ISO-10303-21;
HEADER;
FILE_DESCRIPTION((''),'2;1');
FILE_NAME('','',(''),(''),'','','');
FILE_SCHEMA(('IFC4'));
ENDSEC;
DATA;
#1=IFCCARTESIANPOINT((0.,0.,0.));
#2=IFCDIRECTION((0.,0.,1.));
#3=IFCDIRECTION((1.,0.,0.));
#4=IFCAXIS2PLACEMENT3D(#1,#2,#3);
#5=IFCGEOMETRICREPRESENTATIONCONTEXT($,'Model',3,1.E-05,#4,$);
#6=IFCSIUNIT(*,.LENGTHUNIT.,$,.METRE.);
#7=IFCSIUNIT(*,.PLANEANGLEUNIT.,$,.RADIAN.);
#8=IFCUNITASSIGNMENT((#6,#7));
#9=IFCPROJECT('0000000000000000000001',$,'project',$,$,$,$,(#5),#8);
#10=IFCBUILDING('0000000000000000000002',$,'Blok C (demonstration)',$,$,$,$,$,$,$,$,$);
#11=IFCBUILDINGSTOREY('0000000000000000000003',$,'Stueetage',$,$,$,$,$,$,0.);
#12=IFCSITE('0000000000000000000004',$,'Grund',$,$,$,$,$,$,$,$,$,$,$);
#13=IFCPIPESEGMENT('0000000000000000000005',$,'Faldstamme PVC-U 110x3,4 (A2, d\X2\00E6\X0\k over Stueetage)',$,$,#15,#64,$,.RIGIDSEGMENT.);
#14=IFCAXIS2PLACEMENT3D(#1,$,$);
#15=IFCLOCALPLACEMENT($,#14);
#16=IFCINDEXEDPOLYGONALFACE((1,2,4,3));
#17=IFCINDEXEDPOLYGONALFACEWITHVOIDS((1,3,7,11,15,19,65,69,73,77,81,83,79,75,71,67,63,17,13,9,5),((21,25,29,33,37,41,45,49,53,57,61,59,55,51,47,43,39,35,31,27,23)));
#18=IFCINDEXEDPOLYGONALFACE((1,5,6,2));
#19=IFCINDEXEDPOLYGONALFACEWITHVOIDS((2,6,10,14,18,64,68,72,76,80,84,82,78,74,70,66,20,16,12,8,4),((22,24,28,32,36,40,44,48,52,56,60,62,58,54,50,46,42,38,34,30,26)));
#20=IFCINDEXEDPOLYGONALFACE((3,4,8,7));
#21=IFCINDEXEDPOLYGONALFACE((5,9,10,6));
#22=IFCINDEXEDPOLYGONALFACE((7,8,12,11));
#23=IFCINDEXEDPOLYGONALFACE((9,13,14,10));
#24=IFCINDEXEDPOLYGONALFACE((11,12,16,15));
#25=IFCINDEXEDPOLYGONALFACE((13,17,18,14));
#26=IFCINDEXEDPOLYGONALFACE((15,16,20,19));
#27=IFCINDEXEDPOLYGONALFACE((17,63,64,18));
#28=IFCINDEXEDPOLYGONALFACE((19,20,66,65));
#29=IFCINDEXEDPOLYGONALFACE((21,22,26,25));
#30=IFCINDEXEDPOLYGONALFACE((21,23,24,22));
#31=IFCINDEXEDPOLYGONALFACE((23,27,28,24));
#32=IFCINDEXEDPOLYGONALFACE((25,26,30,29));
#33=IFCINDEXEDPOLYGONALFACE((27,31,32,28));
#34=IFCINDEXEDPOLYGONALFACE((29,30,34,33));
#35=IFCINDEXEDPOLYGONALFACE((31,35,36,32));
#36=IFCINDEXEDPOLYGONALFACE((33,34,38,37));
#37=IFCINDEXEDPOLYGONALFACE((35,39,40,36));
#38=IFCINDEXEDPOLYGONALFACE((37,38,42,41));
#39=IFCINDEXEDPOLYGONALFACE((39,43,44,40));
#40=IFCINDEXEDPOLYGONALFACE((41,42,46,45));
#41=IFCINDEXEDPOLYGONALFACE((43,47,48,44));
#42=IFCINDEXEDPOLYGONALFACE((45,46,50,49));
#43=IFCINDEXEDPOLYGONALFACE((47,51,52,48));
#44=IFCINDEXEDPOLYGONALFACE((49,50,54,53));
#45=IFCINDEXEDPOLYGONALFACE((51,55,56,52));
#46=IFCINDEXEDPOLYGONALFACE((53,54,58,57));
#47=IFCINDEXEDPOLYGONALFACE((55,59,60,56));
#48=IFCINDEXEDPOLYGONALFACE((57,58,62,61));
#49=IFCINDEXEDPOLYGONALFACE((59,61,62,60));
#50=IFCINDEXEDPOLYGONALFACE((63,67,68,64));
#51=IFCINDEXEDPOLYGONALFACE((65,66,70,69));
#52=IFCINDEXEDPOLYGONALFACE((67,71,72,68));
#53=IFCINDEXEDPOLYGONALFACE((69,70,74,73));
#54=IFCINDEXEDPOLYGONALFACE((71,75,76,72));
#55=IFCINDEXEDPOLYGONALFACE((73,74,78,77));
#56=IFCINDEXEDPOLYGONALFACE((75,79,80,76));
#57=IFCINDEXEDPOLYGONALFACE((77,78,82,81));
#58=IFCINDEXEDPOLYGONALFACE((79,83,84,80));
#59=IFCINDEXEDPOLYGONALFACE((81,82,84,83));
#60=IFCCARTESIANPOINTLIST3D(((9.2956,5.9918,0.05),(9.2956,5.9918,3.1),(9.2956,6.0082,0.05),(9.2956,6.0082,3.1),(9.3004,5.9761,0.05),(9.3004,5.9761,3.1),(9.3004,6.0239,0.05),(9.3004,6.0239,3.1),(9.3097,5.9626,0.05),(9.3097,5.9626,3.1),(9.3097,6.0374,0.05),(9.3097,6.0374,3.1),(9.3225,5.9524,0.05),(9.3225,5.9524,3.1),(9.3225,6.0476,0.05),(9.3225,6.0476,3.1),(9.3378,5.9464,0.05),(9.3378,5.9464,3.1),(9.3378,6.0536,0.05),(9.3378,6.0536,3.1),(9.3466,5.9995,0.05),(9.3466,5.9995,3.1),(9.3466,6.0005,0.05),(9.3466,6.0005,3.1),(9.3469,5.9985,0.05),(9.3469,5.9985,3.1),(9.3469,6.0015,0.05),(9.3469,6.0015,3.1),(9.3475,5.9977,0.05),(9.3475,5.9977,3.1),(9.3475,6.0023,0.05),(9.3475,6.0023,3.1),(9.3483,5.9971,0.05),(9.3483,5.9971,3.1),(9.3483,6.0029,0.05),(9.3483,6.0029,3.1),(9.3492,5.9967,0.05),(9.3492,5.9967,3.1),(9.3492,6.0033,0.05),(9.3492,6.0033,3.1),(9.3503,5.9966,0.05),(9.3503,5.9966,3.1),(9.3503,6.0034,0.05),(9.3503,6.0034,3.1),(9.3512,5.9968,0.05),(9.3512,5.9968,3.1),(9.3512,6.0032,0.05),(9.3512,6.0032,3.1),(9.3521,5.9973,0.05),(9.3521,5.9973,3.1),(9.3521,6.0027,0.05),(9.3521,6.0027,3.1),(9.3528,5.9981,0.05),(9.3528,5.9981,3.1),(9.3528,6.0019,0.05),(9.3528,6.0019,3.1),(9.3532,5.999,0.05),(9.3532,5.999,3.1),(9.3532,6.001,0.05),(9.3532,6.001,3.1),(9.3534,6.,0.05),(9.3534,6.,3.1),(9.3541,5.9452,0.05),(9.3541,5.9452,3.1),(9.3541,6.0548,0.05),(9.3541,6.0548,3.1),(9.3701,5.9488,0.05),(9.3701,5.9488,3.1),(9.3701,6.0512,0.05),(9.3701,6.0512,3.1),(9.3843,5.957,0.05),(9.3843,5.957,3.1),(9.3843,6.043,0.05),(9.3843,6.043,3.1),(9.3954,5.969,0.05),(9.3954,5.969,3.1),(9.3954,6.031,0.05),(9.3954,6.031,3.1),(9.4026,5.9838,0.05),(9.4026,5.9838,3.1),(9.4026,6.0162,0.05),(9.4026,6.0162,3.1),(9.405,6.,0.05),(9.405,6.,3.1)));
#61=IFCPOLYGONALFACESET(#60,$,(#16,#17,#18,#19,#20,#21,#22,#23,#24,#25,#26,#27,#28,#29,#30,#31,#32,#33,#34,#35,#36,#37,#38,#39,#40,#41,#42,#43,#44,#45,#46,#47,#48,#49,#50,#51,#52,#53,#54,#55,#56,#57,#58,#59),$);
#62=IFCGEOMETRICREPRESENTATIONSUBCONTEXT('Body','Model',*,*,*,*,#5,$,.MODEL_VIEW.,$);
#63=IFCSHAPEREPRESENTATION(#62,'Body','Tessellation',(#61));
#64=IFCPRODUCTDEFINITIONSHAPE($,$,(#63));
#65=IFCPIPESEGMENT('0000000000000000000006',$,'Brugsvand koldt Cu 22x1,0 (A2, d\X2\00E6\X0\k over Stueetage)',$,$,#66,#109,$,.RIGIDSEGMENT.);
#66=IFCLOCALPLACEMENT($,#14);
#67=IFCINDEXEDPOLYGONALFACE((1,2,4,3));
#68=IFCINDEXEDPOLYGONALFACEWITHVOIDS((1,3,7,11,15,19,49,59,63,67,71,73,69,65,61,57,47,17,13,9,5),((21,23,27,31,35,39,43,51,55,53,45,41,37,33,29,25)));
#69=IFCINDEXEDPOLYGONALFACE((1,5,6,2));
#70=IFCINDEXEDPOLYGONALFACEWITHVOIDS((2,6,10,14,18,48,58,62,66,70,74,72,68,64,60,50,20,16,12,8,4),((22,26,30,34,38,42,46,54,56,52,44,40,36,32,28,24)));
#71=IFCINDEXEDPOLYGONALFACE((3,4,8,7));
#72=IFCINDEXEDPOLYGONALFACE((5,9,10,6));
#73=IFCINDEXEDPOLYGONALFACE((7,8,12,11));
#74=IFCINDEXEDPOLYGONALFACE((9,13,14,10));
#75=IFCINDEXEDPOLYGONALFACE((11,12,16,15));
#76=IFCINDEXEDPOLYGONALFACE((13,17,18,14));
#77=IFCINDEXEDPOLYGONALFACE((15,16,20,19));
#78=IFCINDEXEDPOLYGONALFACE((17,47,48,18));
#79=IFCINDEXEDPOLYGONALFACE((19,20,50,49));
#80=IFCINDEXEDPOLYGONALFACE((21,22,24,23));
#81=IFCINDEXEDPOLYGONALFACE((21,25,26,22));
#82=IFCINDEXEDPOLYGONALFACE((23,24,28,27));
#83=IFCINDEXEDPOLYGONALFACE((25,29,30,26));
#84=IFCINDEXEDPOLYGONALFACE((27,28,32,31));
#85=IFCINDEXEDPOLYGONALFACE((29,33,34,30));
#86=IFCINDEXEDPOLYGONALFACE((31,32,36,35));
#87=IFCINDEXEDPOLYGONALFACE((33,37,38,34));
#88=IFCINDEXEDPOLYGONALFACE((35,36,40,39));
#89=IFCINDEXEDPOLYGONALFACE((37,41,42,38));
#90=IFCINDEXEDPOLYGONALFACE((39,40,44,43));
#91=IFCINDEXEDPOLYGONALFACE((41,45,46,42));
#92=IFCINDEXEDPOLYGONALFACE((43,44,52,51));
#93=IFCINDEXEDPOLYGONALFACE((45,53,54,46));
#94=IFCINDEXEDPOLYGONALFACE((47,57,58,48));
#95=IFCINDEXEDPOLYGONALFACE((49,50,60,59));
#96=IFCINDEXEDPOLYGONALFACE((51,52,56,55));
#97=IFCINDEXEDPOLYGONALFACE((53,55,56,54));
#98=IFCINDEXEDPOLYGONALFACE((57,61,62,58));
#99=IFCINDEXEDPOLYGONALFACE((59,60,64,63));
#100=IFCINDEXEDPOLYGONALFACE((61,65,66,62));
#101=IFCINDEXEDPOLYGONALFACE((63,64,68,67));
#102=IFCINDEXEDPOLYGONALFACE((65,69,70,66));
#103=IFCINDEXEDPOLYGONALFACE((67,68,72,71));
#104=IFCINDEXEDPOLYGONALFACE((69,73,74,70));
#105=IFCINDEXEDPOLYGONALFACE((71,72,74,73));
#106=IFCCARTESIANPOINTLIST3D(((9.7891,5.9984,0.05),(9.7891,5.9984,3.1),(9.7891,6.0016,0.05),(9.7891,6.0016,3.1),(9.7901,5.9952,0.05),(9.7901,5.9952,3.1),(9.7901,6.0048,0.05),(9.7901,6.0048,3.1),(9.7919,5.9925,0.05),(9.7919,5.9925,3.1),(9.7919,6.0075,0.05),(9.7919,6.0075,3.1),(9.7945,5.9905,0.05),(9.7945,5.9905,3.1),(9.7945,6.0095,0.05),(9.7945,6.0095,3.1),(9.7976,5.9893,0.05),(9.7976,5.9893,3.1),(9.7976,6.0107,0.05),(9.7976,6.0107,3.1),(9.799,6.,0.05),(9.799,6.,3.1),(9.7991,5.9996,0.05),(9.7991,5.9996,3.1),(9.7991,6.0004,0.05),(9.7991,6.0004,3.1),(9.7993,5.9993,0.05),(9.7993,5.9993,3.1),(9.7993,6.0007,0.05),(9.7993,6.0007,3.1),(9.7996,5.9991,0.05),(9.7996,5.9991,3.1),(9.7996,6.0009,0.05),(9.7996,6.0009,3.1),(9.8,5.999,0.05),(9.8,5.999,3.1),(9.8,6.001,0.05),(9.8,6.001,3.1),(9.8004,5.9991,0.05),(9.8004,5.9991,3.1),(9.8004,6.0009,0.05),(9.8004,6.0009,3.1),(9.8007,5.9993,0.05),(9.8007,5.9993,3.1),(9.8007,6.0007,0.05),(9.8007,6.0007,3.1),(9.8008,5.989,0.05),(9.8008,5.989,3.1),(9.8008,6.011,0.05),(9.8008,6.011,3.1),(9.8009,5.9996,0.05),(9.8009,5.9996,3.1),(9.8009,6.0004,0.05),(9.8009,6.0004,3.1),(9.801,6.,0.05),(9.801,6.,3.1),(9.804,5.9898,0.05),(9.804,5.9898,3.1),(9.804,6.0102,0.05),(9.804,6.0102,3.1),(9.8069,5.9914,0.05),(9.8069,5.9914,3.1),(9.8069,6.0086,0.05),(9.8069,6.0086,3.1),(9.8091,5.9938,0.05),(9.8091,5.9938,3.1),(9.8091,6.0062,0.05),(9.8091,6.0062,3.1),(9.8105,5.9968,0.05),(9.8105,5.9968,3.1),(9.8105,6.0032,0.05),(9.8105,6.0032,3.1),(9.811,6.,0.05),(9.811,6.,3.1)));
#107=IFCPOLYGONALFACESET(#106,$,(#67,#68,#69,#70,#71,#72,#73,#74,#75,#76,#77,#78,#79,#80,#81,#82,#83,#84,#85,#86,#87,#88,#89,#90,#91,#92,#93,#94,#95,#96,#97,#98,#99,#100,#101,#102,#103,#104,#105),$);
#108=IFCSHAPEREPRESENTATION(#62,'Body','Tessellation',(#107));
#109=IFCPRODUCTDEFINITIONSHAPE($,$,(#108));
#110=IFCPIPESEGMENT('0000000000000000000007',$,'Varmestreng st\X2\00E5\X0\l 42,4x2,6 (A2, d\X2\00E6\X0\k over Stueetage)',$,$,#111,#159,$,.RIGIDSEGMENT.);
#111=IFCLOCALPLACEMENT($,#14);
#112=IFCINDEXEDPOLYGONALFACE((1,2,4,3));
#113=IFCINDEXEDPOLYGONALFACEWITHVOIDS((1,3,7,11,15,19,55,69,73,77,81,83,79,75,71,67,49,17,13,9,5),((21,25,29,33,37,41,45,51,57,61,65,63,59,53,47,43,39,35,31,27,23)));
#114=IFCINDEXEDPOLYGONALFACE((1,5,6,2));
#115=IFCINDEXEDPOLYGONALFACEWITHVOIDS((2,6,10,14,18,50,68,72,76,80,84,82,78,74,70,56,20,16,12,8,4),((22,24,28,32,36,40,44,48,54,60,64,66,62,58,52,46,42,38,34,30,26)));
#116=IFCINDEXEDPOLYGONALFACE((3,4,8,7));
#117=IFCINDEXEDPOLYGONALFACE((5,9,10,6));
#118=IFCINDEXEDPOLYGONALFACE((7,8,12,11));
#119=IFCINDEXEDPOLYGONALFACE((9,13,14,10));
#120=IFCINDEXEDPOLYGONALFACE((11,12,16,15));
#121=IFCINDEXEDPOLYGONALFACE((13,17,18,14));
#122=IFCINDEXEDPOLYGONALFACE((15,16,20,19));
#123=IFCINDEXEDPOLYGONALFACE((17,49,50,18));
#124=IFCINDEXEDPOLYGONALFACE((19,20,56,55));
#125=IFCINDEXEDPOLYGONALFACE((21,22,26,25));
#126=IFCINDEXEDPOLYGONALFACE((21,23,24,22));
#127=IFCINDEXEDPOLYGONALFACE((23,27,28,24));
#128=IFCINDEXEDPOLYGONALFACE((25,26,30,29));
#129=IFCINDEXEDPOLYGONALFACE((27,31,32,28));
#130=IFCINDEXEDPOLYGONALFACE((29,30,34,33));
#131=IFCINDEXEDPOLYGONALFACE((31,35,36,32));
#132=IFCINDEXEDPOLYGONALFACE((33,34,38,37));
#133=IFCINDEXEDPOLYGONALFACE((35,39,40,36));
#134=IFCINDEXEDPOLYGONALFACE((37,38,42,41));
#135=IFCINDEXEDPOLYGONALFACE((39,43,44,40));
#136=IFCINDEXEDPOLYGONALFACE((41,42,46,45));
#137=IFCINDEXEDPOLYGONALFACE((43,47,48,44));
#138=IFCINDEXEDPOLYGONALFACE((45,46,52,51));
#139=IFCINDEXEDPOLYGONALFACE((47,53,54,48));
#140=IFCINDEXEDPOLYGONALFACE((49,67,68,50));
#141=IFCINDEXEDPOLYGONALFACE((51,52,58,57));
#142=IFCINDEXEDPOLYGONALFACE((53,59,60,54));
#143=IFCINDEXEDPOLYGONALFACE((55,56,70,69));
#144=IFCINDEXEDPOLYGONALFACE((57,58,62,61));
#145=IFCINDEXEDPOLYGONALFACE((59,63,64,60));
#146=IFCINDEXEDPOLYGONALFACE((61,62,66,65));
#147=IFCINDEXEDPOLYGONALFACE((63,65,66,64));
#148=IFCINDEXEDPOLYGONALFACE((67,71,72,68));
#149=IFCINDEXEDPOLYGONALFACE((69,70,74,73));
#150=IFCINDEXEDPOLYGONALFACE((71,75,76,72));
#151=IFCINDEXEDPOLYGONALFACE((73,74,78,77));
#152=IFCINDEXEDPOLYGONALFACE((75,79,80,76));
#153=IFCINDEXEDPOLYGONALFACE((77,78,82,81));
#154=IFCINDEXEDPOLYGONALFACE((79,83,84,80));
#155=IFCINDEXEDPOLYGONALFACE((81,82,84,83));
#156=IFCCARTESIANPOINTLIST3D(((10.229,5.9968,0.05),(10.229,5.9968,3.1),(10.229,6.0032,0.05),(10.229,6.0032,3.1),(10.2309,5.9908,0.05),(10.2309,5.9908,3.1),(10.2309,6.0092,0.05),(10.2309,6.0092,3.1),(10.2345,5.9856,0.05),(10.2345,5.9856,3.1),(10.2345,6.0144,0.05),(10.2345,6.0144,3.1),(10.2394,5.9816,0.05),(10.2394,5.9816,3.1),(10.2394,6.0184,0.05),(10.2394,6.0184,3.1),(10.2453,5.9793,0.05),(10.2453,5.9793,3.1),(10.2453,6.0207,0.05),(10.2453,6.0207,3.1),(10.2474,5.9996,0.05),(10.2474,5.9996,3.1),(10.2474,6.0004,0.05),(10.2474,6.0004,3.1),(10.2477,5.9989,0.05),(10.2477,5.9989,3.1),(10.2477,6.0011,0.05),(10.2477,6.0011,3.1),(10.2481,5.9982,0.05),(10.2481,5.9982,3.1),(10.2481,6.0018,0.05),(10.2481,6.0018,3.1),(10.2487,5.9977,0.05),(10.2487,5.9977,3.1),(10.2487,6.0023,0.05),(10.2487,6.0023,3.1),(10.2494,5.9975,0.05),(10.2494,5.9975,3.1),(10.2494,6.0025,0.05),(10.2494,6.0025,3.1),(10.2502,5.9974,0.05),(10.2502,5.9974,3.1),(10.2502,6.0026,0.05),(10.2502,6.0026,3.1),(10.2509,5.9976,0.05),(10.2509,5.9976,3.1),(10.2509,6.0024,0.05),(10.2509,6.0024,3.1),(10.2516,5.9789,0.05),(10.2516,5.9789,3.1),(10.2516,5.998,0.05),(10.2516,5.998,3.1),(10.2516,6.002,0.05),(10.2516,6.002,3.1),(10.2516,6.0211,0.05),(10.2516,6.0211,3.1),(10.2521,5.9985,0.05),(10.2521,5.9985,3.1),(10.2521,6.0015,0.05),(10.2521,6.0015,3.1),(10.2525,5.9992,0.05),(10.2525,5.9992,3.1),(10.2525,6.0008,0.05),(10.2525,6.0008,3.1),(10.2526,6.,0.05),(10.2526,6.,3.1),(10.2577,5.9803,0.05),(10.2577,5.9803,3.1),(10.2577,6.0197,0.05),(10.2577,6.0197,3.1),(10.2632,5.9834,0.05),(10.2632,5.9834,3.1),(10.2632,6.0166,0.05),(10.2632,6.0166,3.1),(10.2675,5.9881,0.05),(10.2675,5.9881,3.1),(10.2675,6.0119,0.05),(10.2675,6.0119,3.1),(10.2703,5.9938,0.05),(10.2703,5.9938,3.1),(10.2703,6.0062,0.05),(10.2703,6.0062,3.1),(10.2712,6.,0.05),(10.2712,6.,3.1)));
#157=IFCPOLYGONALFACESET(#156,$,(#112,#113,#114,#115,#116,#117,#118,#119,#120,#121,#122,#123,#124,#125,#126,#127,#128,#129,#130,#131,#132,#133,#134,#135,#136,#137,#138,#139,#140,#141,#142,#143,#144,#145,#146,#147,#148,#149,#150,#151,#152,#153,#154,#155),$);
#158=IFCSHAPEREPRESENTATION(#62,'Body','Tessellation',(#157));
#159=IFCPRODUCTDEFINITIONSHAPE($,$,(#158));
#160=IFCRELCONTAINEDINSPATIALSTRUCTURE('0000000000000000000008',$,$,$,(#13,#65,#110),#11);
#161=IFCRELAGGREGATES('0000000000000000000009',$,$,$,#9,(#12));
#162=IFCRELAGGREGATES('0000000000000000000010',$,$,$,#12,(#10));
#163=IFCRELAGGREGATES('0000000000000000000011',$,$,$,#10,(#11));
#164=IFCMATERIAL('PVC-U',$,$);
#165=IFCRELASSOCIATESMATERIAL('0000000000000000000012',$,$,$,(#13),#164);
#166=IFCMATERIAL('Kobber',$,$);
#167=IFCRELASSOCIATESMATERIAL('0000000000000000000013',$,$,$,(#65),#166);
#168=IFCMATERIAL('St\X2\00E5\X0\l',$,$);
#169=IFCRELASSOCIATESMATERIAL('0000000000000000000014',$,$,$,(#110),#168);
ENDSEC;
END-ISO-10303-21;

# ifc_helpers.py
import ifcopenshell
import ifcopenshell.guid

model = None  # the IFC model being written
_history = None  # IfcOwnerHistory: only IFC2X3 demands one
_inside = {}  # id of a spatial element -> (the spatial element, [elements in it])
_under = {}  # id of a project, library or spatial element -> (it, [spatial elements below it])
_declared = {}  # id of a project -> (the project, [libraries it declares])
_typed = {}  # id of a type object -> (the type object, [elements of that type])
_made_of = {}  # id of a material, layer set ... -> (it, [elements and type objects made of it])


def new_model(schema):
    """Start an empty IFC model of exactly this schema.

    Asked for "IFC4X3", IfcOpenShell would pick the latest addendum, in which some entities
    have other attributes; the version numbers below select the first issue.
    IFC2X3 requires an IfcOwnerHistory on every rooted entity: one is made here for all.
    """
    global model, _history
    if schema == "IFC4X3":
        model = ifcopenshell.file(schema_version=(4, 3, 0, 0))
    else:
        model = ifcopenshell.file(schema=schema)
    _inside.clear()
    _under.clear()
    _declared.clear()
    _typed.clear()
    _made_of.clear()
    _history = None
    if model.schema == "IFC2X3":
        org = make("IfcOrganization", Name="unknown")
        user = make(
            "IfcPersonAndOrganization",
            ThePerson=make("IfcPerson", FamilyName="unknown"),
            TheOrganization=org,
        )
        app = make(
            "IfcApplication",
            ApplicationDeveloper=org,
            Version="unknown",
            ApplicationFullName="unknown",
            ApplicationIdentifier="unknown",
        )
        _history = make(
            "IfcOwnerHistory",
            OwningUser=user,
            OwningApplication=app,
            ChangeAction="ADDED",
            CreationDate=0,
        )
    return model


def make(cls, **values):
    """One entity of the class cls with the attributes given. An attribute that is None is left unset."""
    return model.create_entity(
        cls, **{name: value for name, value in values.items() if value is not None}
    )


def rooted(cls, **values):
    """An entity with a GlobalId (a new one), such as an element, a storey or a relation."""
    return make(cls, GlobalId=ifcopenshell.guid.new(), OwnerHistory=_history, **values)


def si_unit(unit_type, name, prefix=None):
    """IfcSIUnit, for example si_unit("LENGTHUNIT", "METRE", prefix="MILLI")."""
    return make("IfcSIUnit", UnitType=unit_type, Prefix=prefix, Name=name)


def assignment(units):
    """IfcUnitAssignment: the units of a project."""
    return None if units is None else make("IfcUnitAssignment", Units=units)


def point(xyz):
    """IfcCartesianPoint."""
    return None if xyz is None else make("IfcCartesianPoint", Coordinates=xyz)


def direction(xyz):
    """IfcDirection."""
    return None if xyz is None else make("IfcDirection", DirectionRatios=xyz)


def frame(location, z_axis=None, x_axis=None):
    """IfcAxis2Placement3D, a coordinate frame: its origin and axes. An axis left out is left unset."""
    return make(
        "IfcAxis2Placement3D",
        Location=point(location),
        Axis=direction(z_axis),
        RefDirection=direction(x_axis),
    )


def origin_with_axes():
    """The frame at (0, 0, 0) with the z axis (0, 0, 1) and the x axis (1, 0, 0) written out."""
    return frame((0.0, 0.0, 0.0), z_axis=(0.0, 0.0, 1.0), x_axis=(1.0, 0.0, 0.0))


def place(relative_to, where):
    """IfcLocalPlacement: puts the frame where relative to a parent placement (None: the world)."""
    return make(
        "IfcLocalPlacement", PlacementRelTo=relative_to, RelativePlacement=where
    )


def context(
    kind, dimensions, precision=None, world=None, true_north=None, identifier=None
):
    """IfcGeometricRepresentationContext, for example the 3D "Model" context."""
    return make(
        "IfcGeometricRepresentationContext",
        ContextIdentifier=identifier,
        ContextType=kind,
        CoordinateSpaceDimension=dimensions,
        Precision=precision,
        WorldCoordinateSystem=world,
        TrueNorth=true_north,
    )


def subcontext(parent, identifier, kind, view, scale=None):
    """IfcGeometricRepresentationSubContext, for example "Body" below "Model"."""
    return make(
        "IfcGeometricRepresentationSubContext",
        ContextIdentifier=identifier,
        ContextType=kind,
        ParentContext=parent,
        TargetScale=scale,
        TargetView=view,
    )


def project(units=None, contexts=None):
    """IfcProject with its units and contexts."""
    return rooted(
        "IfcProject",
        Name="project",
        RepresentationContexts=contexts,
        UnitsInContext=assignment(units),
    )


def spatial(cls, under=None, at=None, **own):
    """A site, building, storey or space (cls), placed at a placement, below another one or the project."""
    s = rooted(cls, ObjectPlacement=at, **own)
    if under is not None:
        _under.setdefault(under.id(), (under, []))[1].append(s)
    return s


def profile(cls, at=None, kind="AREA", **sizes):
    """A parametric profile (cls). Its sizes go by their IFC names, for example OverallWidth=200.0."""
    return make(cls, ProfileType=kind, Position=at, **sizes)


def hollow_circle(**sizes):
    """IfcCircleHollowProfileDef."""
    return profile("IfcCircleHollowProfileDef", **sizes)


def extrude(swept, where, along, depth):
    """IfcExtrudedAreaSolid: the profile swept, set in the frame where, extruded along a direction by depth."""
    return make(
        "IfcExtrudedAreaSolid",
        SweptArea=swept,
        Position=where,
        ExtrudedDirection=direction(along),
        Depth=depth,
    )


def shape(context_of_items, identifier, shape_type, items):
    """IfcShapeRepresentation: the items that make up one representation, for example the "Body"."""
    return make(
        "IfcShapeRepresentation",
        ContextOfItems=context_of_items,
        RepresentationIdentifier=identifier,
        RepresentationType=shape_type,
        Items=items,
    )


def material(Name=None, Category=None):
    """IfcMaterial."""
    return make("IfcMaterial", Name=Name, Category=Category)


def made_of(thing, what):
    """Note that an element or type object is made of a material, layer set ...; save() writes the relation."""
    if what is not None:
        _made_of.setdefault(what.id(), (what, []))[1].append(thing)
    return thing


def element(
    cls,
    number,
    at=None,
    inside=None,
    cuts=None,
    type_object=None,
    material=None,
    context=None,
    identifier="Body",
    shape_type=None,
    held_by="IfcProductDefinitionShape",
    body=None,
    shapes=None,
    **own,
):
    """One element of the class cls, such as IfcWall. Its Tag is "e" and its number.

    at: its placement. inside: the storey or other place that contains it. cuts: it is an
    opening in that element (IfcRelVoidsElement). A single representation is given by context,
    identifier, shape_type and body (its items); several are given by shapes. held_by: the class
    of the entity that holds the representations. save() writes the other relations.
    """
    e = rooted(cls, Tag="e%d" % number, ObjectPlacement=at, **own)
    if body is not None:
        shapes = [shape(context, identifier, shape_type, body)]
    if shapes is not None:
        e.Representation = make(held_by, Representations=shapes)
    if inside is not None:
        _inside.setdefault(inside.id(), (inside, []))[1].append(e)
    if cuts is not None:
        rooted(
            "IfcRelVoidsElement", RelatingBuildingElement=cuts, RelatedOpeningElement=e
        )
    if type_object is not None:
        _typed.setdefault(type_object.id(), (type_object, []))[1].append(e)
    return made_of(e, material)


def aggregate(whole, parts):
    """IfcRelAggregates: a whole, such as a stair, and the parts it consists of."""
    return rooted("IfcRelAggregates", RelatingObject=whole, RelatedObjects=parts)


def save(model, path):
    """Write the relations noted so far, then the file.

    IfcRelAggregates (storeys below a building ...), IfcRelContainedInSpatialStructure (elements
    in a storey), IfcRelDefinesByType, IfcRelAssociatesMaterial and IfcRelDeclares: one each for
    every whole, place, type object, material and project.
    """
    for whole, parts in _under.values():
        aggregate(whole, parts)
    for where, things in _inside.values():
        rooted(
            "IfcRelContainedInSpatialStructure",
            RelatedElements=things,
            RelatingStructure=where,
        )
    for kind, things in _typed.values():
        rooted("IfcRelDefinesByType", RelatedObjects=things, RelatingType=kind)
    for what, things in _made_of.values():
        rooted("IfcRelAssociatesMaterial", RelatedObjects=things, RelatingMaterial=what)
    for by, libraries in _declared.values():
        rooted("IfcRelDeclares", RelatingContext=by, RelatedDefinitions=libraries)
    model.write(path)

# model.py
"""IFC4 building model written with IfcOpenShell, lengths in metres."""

from ifc_helpers import new_model, si_unit, frame, origin_with_axes, place, context, subcontext, project, spatial, hollow_circle, extrude, material, element, save


model = new_model("IFC4")

# Units and contexts
model_context = context("Model", 3, precision=1e-05, world=origin_with_axes())
body_context = subcontext(model_context, "Body", "Model", "MODEL_VIEW")
ifc_project = project(units=[si_unit("LENGTHUNIT", "METRE"), si_unit("PLANEANGLEUNIT", "RADIAN")], contexts=[model_context])

# Site, building, storey
site = spatial("IfcSite", under=ifc_project, Name="Grund")
building = spatial("IfcBuilding", under=site, Name="Blok C (demonstration)")
storey = spatial("IfcBuildingStorey", under=building, Name="Stueetage", Elevation=0.0)

# Pipe segments
ifc_material_1 = material(Name="PVC-U")
ifc_material_2 = material(Name="Kobber")
ifc_material_3 = material(Name="Stål")
pipe_segment_1_placement = place(None, origin_with_axes())
element("IfcPipeSegment", 1, at=pipe_segment_1_placement, inside=storey, material=ifc_material_1, Name="Faldstamme PVC-U 110x3,4 (A2, dæk over Stueetage)", PredefinedType="RIGIDSEGMENT", context=body_context, shape_type="SweptSolid", body=[
    extrude(hollow_circle(Radius=0.055, WallThickness=0.0516), frame((9.35, 6.0, 0.05), z_axis=(0.0, 0.0, 1.0), x_axis=(1.0, 0.0, 0.0)), (0.0, 0.0, 1.0), 3.05),
])
pipe_segment_2_placement = place(None, origin_with_axes())
element("IfcPipeSegment", 2, at=pipe_segment_2_placement, inside=storey, material=ifc_material_2, Name="Brugsvand koldt Cu 22x1,0 (A2, dæk over Stueetage)", PredefinedType="RIGIDSEGMENT", context=body_context, shape_type="SweptSolid", body=[
    extrude(hollow_circle(Radius=0.011, WallThickness=0.01), frame((9.8, 6.0, 0.05), z_axis=(0.0, 0.0, 1.0), x_axis=(1.0, 0.0, 0.0)), (0.0, 0.0, 1.0), 3.05),
])
pipe_segment_3_placement = place(None, origin_with_axes())
element("IfcPipeSegment", 3, at=pipe_segment_3_placement, inside=storey, material=ifc_material_3, Name="Varmestreng stål 42,4x2,6 (A2, dæk over Stueetage)", PredefinedType="RIGIDSEGMENT", context=body_context, shape_type="SweptSolid", body=[
    extrude(hollow_circle(Radius=0.0212, WallThickness=0.0186), frame((10.25, 6.0, 0.05), z_axis=(0.0, 0.0, 1.0), x_axis=(1.0, 0.0, 0.0)), (0.0, 0.0, 1.0), 3.05),
])

save(model, "model.ifc")
